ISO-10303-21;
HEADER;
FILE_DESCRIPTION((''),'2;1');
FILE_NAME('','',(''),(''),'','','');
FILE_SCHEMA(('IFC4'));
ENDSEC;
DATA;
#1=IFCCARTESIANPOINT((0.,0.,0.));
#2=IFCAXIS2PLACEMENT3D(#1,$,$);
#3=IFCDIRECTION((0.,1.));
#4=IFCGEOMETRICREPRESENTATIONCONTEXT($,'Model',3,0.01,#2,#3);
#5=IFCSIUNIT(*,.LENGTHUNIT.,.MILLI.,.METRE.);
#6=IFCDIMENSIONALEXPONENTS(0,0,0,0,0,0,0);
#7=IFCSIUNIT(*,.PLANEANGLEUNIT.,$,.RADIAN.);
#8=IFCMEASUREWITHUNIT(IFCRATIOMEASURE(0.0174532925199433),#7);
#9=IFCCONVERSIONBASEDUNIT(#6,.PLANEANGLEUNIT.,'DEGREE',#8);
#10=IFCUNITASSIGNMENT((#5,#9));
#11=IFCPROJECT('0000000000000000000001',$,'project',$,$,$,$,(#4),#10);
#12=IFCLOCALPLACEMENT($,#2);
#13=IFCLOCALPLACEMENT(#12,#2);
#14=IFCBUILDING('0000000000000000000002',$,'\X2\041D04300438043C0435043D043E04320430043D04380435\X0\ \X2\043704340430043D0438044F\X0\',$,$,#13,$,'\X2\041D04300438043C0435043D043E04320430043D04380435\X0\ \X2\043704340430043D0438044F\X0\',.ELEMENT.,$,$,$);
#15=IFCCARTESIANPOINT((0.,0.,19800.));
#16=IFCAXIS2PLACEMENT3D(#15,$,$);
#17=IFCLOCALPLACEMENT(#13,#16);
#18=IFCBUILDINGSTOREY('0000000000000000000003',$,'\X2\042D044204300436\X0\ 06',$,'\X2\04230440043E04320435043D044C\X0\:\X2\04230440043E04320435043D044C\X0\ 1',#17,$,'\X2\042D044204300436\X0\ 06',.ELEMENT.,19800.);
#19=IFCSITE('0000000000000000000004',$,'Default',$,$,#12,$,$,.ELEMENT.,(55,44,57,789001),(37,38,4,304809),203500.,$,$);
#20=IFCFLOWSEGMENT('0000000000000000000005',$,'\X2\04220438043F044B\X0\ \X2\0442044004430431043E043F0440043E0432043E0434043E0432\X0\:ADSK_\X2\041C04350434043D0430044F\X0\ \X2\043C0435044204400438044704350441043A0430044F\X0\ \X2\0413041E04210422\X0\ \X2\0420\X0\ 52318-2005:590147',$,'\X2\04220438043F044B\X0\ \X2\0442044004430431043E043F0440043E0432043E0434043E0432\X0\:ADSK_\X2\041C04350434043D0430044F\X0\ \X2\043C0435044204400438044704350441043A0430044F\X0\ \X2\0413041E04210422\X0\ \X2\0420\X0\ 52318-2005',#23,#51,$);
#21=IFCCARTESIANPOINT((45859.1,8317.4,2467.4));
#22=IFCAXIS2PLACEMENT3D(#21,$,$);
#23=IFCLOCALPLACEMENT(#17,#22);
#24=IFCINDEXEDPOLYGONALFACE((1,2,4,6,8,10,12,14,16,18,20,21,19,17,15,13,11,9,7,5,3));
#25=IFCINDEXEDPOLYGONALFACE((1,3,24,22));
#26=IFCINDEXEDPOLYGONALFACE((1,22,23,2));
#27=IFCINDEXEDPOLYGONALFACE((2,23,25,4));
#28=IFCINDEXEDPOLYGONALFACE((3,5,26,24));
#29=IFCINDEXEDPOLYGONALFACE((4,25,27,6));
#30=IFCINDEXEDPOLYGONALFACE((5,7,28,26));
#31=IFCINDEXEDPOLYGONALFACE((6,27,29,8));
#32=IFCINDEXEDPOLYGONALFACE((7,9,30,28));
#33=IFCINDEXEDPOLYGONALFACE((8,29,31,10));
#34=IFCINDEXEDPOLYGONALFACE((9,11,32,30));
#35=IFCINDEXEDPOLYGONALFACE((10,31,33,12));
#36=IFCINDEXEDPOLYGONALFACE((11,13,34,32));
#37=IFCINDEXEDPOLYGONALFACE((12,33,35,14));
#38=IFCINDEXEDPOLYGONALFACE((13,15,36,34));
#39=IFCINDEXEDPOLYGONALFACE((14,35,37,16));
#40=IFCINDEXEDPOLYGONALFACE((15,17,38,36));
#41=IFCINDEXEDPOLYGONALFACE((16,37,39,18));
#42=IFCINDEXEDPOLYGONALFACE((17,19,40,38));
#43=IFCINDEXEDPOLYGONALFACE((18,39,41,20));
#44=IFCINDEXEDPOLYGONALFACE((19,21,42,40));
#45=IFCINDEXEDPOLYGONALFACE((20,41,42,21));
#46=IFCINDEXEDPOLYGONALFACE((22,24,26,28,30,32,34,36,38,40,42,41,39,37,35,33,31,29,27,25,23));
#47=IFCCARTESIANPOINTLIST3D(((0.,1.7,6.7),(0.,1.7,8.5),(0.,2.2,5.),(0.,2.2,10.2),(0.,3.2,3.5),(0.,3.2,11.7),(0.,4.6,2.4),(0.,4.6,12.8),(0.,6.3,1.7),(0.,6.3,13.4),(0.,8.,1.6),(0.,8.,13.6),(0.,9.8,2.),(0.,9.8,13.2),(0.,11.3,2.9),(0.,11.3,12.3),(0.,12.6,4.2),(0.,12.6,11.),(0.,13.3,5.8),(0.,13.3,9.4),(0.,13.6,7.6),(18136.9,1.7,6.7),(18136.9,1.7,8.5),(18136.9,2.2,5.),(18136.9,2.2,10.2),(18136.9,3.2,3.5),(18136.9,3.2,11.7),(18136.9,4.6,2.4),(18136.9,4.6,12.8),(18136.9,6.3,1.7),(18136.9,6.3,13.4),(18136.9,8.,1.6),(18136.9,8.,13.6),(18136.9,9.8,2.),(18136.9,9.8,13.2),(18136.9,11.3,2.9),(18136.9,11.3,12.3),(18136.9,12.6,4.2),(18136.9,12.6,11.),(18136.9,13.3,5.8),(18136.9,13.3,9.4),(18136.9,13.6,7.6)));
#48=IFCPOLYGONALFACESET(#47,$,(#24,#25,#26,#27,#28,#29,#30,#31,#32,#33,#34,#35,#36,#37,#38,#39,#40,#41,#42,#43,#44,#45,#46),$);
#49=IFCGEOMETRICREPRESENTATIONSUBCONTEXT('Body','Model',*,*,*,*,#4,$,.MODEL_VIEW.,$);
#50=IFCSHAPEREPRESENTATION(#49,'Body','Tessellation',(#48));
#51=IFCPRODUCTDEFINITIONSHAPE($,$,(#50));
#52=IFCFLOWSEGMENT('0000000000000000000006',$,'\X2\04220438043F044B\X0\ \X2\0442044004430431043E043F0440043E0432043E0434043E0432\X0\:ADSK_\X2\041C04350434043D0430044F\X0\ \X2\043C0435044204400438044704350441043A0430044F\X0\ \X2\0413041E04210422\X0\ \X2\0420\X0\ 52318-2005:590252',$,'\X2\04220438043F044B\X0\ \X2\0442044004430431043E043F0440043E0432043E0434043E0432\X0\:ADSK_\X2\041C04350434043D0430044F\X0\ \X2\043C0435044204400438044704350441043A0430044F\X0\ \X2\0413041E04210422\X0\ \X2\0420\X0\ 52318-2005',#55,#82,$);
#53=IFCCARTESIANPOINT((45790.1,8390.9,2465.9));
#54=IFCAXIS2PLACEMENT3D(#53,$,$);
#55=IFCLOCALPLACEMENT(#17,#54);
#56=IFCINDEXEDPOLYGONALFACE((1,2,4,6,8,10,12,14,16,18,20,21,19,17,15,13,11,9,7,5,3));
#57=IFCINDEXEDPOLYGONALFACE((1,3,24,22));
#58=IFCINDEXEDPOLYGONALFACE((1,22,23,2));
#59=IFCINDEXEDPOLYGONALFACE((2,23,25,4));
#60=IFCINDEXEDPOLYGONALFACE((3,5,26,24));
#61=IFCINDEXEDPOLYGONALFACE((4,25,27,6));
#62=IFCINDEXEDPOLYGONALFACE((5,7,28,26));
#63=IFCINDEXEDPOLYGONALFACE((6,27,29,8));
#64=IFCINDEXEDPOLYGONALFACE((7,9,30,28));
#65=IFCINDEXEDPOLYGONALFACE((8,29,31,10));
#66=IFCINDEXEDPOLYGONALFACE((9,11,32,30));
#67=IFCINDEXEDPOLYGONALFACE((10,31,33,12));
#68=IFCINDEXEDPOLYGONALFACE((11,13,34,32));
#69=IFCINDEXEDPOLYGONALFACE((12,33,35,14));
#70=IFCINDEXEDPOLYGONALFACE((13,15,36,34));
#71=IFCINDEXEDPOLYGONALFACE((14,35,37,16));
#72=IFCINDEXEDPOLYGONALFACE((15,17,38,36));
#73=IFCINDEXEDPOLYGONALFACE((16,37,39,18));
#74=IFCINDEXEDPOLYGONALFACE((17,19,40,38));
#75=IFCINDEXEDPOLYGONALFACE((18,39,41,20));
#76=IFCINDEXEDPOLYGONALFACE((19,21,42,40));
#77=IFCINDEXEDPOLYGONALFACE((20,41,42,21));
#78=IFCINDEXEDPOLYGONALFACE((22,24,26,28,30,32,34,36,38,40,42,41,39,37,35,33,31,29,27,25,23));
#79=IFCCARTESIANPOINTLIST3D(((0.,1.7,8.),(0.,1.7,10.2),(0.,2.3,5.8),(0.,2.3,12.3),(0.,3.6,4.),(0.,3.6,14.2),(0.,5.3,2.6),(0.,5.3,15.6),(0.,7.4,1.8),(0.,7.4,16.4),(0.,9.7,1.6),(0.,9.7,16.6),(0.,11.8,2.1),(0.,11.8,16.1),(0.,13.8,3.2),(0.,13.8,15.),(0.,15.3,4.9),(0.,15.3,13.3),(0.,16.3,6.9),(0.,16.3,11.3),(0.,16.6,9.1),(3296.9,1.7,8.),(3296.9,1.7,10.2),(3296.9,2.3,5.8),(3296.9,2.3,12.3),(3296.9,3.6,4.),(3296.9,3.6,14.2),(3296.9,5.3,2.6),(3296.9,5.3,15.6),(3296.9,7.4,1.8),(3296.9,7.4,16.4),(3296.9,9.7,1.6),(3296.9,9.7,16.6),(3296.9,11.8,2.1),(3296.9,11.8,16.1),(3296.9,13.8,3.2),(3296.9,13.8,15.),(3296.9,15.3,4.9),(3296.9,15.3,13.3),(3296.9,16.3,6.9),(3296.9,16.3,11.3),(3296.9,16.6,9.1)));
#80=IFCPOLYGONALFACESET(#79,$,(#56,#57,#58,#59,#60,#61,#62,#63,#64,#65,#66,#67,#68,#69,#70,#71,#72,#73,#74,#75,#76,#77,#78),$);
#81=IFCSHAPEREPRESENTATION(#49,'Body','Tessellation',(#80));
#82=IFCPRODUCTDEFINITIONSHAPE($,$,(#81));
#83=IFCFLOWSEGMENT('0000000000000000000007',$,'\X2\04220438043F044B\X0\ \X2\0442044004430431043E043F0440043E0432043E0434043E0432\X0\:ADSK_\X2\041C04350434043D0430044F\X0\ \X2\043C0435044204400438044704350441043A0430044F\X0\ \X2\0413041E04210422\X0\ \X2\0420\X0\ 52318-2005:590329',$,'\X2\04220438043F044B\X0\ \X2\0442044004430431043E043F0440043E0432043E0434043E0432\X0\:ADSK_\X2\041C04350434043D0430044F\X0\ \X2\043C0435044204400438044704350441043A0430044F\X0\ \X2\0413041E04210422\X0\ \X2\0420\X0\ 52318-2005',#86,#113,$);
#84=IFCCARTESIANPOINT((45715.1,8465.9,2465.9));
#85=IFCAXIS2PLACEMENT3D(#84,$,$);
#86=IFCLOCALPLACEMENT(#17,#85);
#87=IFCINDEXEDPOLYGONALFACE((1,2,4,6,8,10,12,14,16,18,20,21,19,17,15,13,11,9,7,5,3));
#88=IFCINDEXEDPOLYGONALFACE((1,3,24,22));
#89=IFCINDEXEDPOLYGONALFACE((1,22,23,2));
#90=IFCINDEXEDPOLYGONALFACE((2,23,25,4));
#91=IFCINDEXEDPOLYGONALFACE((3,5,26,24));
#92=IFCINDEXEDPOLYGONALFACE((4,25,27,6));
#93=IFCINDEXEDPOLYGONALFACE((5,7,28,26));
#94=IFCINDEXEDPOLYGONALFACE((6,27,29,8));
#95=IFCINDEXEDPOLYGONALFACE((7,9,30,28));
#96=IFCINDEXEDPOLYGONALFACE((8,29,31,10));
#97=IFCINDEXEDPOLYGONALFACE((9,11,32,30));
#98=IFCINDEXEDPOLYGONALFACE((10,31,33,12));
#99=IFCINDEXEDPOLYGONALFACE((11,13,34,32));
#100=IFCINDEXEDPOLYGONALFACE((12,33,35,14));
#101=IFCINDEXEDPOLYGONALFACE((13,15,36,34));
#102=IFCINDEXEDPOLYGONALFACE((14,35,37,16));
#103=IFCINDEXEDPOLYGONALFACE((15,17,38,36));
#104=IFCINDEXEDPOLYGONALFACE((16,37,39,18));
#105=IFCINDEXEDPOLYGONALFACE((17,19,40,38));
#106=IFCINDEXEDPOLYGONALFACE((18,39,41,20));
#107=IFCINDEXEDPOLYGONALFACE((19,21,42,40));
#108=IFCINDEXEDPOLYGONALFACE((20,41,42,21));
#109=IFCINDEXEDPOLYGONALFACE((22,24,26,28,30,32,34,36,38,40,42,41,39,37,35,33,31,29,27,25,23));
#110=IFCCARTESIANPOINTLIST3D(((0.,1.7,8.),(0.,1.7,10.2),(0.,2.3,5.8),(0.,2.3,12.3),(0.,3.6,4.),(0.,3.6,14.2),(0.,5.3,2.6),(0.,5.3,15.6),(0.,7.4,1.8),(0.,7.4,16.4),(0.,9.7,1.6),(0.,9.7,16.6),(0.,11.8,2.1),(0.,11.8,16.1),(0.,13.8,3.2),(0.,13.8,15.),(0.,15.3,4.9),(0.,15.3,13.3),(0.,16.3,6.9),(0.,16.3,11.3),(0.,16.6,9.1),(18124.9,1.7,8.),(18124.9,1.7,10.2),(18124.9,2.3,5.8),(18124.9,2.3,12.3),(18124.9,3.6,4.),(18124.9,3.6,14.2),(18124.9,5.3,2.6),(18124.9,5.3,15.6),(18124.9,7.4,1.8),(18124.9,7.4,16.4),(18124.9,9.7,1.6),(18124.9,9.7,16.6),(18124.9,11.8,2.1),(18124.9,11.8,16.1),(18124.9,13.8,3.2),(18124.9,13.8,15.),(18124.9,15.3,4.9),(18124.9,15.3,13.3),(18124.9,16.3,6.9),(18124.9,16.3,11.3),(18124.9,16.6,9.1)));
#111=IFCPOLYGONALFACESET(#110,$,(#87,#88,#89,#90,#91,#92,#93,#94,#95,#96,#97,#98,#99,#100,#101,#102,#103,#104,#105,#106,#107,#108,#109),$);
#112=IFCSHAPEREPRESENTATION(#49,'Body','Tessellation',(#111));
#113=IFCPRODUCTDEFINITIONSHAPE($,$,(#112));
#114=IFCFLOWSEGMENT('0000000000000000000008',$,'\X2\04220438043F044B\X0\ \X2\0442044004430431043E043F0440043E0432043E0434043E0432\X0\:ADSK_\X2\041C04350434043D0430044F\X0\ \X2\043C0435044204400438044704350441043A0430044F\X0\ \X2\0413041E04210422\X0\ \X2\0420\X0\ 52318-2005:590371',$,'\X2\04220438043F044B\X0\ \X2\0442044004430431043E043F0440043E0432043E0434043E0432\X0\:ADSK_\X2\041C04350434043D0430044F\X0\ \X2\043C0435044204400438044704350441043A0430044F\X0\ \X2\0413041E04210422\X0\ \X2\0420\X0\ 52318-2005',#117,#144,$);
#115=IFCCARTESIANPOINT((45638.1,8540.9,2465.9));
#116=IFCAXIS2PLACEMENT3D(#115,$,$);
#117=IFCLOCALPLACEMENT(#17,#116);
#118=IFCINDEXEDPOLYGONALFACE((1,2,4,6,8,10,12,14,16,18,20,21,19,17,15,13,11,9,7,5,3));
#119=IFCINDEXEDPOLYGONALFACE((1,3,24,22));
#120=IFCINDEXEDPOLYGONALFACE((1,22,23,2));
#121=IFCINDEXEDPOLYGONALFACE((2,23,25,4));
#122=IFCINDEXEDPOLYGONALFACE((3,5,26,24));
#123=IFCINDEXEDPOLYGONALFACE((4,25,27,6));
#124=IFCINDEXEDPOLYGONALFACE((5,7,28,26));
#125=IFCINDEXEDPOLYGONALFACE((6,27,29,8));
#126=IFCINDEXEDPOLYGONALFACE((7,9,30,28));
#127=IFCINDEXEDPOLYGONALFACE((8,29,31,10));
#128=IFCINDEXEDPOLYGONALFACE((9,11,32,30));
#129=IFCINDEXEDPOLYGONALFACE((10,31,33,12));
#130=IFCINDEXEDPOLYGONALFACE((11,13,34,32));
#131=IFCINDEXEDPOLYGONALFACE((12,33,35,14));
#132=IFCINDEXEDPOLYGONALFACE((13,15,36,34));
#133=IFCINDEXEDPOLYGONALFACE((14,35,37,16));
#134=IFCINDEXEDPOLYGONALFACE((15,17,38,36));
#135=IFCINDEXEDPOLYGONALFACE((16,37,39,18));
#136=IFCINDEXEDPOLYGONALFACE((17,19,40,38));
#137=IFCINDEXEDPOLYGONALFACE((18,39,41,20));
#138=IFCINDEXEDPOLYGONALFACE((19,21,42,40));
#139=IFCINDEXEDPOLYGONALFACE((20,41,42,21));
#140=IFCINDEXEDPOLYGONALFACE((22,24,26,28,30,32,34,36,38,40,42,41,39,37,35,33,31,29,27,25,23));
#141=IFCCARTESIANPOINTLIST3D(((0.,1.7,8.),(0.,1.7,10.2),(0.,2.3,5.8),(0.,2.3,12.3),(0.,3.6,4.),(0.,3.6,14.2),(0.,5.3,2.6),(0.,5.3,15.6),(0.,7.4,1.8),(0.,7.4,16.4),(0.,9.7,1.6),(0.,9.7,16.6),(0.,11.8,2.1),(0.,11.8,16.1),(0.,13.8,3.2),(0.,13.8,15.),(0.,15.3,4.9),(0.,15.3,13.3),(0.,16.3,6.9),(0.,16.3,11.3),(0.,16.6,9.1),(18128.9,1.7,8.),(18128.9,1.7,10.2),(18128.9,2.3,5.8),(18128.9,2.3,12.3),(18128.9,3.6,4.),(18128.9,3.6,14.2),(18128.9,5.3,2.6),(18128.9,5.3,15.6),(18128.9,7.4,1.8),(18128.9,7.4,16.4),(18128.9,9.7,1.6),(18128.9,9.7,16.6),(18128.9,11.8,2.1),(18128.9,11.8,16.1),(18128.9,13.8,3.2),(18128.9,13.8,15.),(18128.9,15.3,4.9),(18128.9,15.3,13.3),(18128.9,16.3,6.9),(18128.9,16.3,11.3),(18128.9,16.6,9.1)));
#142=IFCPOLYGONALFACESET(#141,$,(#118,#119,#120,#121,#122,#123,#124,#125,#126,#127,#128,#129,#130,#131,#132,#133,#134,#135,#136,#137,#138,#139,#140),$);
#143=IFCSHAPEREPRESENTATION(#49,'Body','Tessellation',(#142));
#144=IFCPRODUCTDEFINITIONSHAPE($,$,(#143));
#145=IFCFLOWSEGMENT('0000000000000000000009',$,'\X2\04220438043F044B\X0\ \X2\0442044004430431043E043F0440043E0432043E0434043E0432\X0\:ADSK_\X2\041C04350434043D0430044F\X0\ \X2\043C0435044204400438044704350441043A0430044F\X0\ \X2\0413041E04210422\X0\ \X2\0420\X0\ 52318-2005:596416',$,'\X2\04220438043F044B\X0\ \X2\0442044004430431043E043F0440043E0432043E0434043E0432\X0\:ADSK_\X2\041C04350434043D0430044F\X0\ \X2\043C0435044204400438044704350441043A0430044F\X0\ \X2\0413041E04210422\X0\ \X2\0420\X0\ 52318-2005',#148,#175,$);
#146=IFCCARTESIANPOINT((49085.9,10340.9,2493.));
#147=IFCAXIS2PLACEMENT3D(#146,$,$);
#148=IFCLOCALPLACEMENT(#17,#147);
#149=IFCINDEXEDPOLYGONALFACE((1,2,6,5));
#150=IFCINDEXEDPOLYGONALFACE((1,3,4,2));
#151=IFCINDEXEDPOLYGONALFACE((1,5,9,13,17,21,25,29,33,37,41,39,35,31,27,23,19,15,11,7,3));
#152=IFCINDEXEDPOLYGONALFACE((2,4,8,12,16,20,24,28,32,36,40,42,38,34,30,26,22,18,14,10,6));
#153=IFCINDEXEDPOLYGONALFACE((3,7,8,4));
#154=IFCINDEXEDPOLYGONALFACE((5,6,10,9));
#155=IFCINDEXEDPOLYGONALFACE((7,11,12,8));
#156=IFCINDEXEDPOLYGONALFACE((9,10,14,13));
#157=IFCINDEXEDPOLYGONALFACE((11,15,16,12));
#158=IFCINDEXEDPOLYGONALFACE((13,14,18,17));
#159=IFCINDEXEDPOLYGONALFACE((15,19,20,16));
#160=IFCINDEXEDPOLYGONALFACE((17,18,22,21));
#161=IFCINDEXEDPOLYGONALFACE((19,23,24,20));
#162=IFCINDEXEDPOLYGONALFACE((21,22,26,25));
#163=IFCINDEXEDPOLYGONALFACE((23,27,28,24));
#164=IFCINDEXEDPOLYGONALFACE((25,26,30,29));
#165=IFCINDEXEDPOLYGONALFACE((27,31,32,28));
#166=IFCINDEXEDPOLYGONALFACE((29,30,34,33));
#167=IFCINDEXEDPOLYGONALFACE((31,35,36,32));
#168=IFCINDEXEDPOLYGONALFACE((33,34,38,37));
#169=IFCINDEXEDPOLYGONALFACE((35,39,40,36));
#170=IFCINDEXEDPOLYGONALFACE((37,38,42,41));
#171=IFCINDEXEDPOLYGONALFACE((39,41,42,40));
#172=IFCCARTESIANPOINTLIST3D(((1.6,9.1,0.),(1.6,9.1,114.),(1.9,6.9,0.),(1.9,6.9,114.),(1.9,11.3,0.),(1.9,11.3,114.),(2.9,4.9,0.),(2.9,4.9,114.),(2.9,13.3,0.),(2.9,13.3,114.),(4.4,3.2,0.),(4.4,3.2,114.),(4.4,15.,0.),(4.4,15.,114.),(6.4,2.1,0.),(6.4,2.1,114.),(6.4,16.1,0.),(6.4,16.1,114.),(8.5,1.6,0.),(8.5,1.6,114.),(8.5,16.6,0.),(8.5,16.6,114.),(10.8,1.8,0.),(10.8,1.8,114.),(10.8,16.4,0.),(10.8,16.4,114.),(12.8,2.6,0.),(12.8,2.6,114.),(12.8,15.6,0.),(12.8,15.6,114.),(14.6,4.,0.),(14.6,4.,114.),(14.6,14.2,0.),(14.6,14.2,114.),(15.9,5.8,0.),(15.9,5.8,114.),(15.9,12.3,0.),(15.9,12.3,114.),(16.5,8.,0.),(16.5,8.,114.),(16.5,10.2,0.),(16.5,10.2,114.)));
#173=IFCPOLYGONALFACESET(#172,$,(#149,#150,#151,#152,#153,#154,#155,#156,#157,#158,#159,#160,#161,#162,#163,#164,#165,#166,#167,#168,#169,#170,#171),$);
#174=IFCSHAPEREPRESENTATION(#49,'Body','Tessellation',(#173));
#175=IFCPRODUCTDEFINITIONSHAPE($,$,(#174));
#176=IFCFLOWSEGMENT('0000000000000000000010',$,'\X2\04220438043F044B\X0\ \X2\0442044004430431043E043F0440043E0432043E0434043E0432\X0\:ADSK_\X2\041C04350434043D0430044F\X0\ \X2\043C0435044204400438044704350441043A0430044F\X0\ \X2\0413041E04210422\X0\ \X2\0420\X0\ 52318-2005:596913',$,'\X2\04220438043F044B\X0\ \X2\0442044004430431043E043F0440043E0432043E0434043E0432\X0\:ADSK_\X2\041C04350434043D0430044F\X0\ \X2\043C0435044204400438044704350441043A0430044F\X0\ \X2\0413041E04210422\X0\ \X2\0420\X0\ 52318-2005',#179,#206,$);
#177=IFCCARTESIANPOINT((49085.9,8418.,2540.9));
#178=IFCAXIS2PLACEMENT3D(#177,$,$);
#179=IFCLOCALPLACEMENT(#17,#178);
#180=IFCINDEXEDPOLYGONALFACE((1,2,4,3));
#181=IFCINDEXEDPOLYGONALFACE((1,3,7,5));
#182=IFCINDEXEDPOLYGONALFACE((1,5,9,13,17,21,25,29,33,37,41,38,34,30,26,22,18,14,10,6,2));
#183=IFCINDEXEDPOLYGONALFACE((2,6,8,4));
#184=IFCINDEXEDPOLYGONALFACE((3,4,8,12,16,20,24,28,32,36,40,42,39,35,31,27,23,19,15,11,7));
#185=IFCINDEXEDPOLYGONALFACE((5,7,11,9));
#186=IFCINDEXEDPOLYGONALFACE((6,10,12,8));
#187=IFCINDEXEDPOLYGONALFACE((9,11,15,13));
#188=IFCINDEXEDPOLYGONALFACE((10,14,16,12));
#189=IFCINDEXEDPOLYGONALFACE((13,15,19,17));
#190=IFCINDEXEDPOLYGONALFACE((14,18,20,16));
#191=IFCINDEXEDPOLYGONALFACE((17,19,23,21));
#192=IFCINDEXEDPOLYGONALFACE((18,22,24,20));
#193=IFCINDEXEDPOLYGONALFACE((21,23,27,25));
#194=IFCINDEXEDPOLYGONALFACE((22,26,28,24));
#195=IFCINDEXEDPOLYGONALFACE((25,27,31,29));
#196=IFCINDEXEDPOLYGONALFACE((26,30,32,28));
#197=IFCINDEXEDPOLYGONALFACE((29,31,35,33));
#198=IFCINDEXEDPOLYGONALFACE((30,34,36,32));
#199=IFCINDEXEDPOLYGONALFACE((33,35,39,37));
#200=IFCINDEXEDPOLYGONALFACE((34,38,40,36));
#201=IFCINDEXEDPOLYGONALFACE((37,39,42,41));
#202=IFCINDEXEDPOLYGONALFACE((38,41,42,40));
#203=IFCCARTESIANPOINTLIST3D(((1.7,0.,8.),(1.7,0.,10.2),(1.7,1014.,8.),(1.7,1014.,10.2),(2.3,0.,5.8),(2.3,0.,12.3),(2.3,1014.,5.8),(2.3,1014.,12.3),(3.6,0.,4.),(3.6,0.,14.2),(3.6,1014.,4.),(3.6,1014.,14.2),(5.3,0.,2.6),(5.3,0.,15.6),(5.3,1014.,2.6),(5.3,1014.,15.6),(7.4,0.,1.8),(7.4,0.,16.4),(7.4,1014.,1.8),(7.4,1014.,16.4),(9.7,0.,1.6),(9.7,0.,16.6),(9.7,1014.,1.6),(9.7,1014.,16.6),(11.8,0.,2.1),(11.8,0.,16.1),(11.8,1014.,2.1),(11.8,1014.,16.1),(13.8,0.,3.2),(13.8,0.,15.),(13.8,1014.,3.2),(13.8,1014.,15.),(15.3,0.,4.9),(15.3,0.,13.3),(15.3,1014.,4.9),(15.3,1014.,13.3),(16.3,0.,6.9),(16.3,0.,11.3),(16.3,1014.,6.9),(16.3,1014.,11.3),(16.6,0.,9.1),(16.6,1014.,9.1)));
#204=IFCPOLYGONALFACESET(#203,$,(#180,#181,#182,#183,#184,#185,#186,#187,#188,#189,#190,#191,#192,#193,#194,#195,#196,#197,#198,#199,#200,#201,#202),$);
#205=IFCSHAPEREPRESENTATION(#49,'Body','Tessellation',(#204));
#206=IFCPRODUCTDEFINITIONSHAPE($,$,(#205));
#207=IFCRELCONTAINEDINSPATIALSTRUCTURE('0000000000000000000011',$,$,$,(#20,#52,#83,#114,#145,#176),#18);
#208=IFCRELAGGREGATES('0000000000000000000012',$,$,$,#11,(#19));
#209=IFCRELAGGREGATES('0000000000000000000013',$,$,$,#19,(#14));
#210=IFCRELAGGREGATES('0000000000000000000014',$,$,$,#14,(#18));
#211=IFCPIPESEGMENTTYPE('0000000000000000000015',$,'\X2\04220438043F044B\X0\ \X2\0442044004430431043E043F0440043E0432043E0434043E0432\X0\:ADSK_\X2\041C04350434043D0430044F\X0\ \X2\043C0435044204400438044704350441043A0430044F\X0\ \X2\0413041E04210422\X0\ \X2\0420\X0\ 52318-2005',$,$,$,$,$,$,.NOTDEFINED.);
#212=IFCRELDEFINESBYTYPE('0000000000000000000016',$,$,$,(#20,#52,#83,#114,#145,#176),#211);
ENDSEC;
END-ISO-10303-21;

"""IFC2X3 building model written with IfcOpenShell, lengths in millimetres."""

from ifc_helpers import new_model, entity, si_unit, converted_unit, direction, frame, frame_2d, origin, origin_2d_with_axis, place, context, subcontext, project, spatial, circle, extrude, type_object, element, save


model = new_model("IFC2X3")

# Units and contexts
model_context = context("Model", 3, precision=0.01, world=origin(), true_north=direction((0.0, 1.0)))
body_context = subcontext(model_context, "Body", "Model", "MODEL_VIEW")
ifc_project = project(units=[si_unit("LENGTHUNIT", "METRE", prefix="MILLI"), converted_unit("PLANEANGLEUNIT", "DEGREE", entity("IfcRatioMeasure", 0.0174532925199433), si_unit("PLANEANGLEUNIT", "RADIAN"), dimensions=[0, 0, 0, 0, 0, 0, 0])], contexts=[model_context])

# Site, building, storey
site_placement = place(None, frame((0.0, 0.0, 0.0)))
site = spatial("IfcSite", under=ifc_project, at=site_placement, Name="Default", CompositionType="ELEMENT", RefLatitude=(55, 44, 57, 789001), RefLongitude=(37, 38, 4, 304809), RefElevation=203500.0)
building_placement = place(site_placement, origin())
building = spatial("IfcBuilding", under=site, at=building_placement, Name="Наименование здания", LongName="Наименование здания", CompositionType="ELEMENT")
storey_placement = place(building_placement, frame((0.0, 0.0, 19800.0)))
storey = spatial("IfcBuildingStorey", under=building, at=storey_placement, Name="Этаж 06", ObjectType="Уровень:Уровень 1", LongName="Этаж 06", CompositionType="ELEMENT", Elevation=19800.0)

# Flow segments
pipe_segment_type = type_object("IfcPipeSegmentType", Name="Типы трубопроводов:ADSK_Медная метрическая ГОСТ Р 52318-2005", PredefinedType="NOTDEFINED")
flow_segment_1_placement = place(storey_placement, frame((45859.1, 8317.4, 2467.4)))
element("IfcFlowSegment", 1, at=flow_segment_1_placement, inside=storey, type_object=pipe_segment_type, Name="Типы трубопроводов:ADSK_Медная метрическая ГОСТ Р 52318-2005:590147", ObjectType="Типы трубопроводов:ADSK_Медная метрическая ГОСТ Р 52318-2005", context=body_context, shape_type="SweptSolid", body=[
    extrude(circle(Radius=6.0, at=frame_2d((0.0, 0.0), x_axis=(1.0, 0.0))), frame((0.0, 7.6, 7.6), z_axis=(1.0, 0.0, 0.0), x_axis=(0.0, 1.0, 0.0)), (0.0, 0.0, 1.0), 18136.9),
])
flow_segment_2_placement = place(storey_placement, frame((45790.1, 8390.9, 2465.9)))
element("IfcFlowSegment", 2, at=flow_segment_2_placement, inside=storey, type_object=pipe_segment_type, Name="Типы трубопроводов:ADSK_Медная метрическая ГОСТ Р 52318-2005:590252", ObjectType="Типы трубопроводов:ADSK_Медная метрическая ГОСТ Р 52318-2005", context=body_context, shape_type="SweptSolid", body=[
    extrude(circle(Radius=7.5, at=frame_2d((0.0, 0.0), x_axis=(1.0, 0.0))), frame((0.0, 9.1, 9.1), z_axis=(1.0, 0.0, 0.0), x_axis=(0.0, 1.0, 0.0)), (0.0, 0.0, 1.0), 3296.9),
])
flow_segment_3_placement = place(storey_placement, frame((45715.1, 8465.9, 2465.9)))
element("IfcFlowSegment", 3, at=flow_segment_3_placement, inside=storey, type_object=pipe_segment_type, Name="Типы трубопроводов:ADSK_Медная метрическая ГОСТ Р 52318-2005:590329", ObjectType="Типы трубопроводов:ADSK_Медная метрическая ГОСТ Р 52318-2005", context=body_context, shape_type="SweptSolid", body=[
    extrude(circle(Radius=7.5, at=frame_2d((0.0, 0.0), x_axis=(1.0, 0.0))), frame((0.0, 9.1, 9.1), z_axis=(1.0, 0.0, 0.0), x_axis=(0.0, 1.0, 0.0)), (0.0, 0.0, 1.0), 18124.9),
])
flow_segment_4_placement = place(storey_placement, frame((45638.1, 8540.9, 2465.9)))
element("IfcFlowSegment", 4, at=flow_segment_4_placement, inside=storey, type_object=pipe_segment_type, Name="Типы трубопроводов:ADSK_Медная метрическая ГОСТ Р 52318-2005:590371", ObjectType="Типы трубопроводов:ADSK_Медная метрическая ГОСТ Р 52318-2005", context=body_context, shape_type="SweptSolid", body=[
    extrude(circle(Radius=7.5, at=frame_2d((0.0, 0.0), x_axis=(1.0, 0.0))), frame((0.0, 9.1, 9.1), z_axis=(1.0, 0.0, 0.0), x_axis=(0.0, 1.0, 0.0)), (0.0, 0.0, 1.0), 18128.9),
])
flow_segment_5_placement = place(storey_placement, frame((49085.9, 10340.9, 2493.0)))
element("IfcFlowSegment", 5, at=flow_segment_5_placement, inside=storey, type_object=pipe_segment_type, Name="Типы трубопроводов:ADSK_Медная метрическая ГОСТ Р 52318-2005:596416", ObjectType="Типы трубопроводов:ADSK_Медная метрическая ГОСТ Р 52318-2005", context=body_context, shape_type="SweptSolid", body=[
    extrude(circle(Radius=7.5, at=origin_2d_with_axis()), frame((9.1, 9.1, 0.0), z_axis=(0.0, 0.0, 1.0), x_axis=(-1.0, 0.0, 0.0)), (0.0, 0.0, 1.0), 114.0),
])
flow_segment_6_placement = place(storey_placement, frame((49085.9, 8418.0, 2540.9)))
element("IfcFlowSegment", 6, at=flow_segment_6_placement, inside=storey, type_object=pipe_segment_type, Name="Типы трубопроводов:ADSK_Медная метрическая ГОСТ Р 52318-2005:596913", ObjectType="Типы трубопроводов:ADSK_Медная метрическая ГОСТ Р 52318-2005", context=body_context, shape_type="SweptSolid", body=[
    extrude(circle(Radius=7.5, at=origin_2d_with_axis()), frame((9.1, 0.0, 9.1), z_axis=(0.0, 1.0, 0.0), x_axis=(1.0, 0.0, 0.0)), (0.0, 0.0, 1.0), 1014.0),
])

save(model, "model.ifc")
